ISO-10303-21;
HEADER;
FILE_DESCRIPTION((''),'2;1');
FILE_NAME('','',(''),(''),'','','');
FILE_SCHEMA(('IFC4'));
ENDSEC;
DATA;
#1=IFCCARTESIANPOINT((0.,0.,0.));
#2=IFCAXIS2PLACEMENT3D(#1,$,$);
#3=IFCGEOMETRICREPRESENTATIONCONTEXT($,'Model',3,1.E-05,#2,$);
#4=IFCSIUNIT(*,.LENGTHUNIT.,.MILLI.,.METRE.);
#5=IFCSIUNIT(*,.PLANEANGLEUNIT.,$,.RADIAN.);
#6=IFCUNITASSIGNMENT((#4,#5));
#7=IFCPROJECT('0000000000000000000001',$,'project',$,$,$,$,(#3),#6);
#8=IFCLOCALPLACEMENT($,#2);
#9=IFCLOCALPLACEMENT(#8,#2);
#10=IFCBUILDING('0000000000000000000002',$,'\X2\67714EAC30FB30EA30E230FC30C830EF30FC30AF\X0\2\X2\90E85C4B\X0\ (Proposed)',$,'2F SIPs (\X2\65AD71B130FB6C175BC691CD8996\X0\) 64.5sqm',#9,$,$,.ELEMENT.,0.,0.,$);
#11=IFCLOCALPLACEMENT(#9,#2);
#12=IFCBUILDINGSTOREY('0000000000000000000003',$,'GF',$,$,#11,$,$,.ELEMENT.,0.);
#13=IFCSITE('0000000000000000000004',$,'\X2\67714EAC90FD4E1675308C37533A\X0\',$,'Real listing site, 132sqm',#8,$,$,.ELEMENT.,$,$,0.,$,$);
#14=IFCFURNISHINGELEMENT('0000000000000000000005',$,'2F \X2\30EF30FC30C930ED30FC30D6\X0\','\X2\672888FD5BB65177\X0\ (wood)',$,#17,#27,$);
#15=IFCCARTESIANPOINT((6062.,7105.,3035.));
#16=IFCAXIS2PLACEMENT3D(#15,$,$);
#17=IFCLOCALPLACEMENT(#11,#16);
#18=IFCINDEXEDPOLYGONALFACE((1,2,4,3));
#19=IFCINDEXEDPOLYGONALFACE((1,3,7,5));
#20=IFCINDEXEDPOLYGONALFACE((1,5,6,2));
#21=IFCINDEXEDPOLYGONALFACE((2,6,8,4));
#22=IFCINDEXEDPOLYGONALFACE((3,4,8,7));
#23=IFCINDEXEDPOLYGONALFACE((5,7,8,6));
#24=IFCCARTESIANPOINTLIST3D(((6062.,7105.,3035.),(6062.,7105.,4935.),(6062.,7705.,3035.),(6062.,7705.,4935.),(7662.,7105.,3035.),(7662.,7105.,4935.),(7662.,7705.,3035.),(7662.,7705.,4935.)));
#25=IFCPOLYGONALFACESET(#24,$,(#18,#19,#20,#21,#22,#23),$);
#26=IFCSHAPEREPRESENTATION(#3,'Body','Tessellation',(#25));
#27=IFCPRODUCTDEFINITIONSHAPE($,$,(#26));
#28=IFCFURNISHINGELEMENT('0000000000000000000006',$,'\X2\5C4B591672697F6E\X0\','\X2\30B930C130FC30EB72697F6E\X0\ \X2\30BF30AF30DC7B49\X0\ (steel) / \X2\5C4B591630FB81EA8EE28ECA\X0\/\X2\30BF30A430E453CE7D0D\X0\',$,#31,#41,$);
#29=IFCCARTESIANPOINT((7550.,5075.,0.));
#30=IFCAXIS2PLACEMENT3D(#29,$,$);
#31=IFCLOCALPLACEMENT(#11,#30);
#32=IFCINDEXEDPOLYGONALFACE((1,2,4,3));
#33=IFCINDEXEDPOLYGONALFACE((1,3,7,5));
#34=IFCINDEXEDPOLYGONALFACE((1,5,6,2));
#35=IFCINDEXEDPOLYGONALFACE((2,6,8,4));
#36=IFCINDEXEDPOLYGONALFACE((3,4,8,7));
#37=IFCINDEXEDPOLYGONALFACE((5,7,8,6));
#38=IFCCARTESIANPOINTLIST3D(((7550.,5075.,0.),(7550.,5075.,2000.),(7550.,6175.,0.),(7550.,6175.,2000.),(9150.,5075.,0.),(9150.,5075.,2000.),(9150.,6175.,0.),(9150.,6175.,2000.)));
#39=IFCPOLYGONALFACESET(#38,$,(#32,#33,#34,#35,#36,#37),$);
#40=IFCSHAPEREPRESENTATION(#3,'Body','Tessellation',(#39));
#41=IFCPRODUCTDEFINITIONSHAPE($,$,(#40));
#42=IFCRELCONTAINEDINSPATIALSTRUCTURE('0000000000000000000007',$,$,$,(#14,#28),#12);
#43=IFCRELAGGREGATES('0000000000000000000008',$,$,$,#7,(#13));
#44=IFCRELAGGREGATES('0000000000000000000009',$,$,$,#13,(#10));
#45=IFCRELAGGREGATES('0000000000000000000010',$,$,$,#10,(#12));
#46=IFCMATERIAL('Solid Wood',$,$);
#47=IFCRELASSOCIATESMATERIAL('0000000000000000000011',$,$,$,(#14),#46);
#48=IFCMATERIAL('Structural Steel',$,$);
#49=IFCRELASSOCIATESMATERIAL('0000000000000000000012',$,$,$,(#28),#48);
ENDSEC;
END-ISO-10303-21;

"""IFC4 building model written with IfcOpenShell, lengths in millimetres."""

from ifc_helpers import new_model, si_unit, frame, frame_2d, origin, place, context, project, spatial, rectangle, extrude, material, element, save


model = new_model("IFC4")

# Units and contexts
model_context = context("Model", 3, precision=1e-05, world=origin())
ifc_project = project(units=[si_unit("LENGTHUNIT", "METRE", prefix="MILLI"), si_unit("PLANEANGLEUNIT", "RADIAN")], contexts=[model_context])

# Site, building, storey
site_placement = place(None, origin())
site = spatial("IfcSite", under=ifc_project, at=site_placement, Name="東京都世田谷区", ObjectType="Real listing site, 132sqm", CompositionType="ELEMENT", RefElevation=0.0)
building_placement = place(site_placement, origin())
building = spatial("IfcBuilding", under=site, at=building_placement, Name="東京・リモートワーク2部屋 (Proposed)", ObjectType="2F SIPs (断熱・気密重視) 64.5sqm", CompositionType="ELEMENT", ElevationOfRefHeight=0.0, ElevationOfTerrain=0.0)
storey_placement = place(building_placement, origin())
storey = spatial("IfcBuildingStorey", under=building, at=storey_placement, Name="GF", CompositionType="ELEMENT", Elevation=0.0)

# Shared definitions
ifc_material_1 = material(Name="Solid Wood")

# Shared definitions
ifc_material_2 = material(Name="Structural Steel")

# Furnishing elements
furnishing_1_placement = place(storey_placement, frame((6062.0, 7105.0, 3035.0)))
element("IfcFurnishingElement", 1, at=furnishing_1_placement, inside=storey, material=ifc_material_1, Name="2F ワードローブ", Description="木製家具 (wood)", context=model_context, shape_type="SweptSolid", body=[
    extrude(rectangle(XDim=1600.0, YDim=600.0, at=frame_2d((800.0, 300.0))), frame((6062.0, 7105.0, 3035.0)), (0.0, 0.0, 1.0), 1900.0),
])
furnishing_2_placement = place(storey_placement, frame((7550.0, 5075.0, 0.0)))
element("IfcFurnishingElement", 2, at=furnishing_2_placement, inside=storey, material=ifc_material_2, Name="屋外物置", Description="スチール物置 タクボ等 (steel) / 屋外・自転車/タイヤ収納", context=model_context, shape_type="SweptSolid", body=[
    extrude(rectangle(XDim=1600.0, YDim=1100.0, at=frame_2d((800.0, 550.0))), frame((7550.0, 5075.0, 0.0)), (0.0, 0.0, 1.0), 2000.0),
])

save(model, "model.ifc")
